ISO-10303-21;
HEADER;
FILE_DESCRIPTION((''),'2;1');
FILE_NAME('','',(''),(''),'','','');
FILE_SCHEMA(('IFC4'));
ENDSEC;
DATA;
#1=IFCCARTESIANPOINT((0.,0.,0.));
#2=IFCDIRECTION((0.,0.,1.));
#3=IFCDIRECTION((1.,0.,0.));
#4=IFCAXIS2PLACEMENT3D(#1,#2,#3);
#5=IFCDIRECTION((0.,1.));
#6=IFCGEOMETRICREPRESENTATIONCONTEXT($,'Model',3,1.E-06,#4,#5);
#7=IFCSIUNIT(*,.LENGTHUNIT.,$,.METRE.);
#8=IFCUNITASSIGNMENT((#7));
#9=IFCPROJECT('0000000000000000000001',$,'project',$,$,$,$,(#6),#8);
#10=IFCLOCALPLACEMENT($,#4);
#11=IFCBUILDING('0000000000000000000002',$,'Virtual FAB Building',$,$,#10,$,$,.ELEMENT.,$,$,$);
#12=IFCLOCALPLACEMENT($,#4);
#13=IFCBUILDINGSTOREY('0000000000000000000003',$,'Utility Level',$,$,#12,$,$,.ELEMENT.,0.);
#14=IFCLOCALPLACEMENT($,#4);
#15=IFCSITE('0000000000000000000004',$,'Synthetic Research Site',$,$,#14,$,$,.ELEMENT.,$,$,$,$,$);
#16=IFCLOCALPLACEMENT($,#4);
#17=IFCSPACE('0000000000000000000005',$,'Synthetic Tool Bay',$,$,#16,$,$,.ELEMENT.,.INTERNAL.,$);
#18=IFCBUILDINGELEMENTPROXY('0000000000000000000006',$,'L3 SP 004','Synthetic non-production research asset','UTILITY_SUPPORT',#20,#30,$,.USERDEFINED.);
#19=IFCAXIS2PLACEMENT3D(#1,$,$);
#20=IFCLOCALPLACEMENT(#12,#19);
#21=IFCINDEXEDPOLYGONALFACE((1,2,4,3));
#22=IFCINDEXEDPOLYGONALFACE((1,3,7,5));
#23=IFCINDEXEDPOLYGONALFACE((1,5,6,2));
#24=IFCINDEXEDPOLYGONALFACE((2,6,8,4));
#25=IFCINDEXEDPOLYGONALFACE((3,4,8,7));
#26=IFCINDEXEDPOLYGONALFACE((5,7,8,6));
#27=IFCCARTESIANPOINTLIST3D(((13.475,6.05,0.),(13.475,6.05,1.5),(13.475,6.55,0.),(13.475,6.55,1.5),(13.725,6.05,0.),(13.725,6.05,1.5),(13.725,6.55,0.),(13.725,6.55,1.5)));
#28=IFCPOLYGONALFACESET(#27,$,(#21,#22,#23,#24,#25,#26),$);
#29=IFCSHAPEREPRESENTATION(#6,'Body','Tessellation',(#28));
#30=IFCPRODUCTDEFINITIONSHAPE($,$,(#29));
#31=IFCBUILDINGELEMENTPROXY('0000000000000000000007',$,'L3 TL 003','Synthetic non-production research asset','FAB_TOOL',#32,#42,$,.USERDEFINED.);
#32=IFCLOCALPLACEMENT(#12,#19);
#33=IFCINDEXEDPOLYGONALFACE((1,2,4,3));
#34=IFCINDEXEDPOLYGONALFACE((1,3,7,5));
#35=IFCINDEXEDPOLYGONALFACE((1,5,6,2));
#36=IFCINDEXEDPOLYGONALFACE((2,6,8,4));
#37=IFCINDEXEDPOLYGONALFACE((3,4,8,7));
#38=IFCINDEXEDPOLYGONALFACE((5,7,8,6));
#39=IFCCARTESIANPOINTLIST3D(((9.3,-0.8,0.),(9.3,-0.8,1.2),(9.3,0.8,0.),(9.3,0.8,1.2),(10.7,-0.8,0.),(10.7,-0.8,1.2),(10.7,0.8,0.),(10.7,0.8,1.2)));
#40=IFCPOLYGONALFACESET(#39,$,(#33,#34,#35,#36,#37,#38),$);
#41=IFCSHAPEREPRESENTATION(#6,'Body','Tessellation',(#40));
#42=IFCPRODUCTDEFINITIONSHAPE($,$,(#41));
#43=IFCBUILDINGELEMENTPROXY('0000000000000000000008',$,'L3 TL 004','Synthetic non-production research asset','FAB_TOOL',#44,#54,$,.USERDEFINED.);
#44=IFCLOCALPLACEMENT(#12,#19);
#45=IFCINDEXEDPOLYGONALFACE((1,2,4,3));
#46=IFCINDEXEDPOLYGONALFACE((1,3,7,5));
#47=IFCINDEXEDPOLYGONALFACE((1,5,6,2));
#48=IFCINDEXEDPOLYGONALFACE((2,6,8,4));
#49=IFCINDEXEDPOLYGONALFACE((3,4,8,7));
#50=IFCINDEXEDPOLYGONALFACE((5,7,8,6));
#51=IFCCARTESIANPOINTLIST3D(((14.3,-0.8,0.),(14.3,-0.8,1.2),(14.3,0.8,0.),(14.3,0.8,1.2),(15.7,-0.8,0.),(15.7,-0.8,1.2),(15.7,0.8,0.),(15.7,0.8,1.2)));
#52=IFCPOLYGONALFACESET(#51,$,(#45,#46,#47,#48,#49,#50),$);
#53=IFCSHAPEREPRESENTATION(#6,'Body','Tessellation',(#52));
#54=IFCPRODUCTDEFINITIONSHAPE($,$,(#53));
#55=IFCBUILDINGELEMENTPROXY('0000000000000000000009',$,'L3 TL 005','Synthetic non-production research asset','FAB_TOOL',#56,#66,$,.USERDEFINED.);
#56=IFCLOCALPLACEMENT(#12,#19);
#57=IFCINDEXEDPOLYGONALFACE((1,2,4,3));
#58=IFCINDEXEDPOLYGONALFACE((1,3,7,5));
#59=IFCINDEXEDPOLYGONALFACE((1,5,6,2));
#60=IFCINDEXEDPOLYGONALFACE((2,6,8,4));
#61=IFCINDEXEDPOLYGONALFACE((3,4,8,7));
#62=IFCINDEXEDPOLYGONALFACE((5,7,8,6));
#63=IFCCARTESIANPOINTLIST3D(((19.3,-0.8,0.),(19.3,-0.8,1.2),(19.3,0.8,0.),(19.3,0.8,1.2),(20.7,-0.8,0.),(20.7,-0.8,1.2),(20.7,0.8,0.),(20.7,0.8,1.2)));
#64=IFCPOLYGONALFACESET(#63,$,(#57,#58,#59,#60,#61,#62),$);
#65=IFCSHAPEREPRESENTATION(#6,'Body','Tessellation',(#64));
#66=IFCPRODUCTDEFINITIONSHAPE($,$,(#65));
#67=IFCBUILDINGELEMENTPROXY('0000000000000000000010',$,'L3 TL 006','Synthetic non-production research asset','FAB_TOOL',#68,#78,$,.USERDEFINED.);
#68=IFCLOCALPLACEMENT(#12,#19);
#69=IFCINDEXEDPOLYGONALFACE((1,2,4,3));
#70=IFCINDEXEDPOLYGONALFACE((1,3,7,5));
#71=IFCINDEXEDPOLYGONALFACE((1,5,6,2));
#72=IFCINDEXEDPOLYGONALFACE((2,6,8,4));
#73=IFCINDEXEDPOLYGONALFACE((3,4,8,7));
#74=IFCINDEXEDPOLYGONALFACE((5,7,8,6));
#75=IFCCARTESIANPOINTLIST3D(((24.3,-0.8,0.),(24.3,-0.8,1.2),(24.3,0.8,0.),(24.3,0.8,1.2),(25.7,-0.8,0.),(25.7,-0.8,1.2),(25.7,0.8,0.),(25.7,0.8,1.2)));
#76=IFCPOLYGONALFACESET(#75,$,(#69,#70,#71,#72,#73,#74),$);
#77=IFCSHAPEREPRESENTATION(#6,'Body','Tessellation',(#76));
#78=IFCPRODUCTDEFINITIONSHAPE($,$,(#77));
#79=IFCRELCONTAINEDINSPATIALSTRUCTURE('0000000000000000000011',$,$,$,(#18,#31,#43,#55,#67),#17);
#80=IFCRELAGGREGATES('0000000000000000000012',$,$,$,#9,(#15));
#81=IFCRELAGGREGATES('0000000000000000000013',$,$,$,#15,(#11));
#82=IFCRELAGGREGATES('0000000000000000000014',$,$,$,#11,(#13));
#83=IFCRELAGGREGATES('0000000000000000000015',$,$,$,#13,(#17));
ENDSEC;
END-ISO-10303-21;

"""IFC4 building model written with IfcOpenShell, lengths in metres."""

from ifc_helpers import new_model, si_unit, direction, frame, origin_with_axes, origin_2d_with_axis, place, context, project, spatial, rectangle, extrude, element, save


model = new_model("IFC4")

# Units and contexts
model_context = context("Model", 3, precision=1e-06, world=origin_with_axes(), true_north=direction((0.0, 1.0)))
ifc_project = project(units=[si_unit("LENGTHUNIT", "METRE")], contexts=[model_context])

# Site, building, storey, space
site_placement = place(None, origin_with_axes())
site = spatial("IfcSite", under=ifc_project, at=site_placement, Name="Synthetic Research Site", CompositionType="ELEMENT")
building_placement = place(None, origin_with_axes())
building = spatial("IfcBuilding", under=site, at=building_placement, Name="Virtual FAB Building", CompositionType="ELEMENT")
storey_placement = place(None, origin_with_axes())
storey = spatial("IfcBuildingStorey", under=building, at=storey_placement, Name="Utility Level", CompositionType="ELEMENT", Elevation=0.0)
space_placement = place(None, origin_with_axes())
space = spatial("IfcSpace", under=storey, at=space_placement, Name="Synthetic Tool Bay", CompositionType="ELEMENT", PredefinedType="INTERNAL")

# Building element proxies
for number, where, z_axis, x_axis, name in (
    (1, (13.6, 6.3, 0.0), (0.0, 0.0, 1.0), (1.0, 0.0, 0.0), "L3 SP 004"),
):
    element("IfcBuildingElementProxy", number, at=place(None, frame(where, z_axis=z_axis, x_axis=x_axis)), inside=space, Name=name, Description="Synthetic non-production research asset", ObjectType="UTILITY_SUPPORT", PredefinedType="USERDEFINED", context=model_context, shape_type="SweptSolid", body=[
        extrude(rectangle(XDim=0.25, YDim=0.5, at=origin_2d_with_axis()), origin_with_axes(), (0.0, 0.0, 1.0), 1.5),
    ])
for number, where, z_axis, x_axis, name in (
    (2, (10.0, 0.0, 0.0), (0.0, 0.0, 1.0), (1.0, 0.0, 0.0), "L3 TL 003"),
    (3, (15.0, 0.0, 0.0), (0.0, 0.0, 1.0), (1.0, 0.0, 0.0), "L3 TL 004"),
    (4, (20.0, 0.0, 0.0), (0.0, 0.0, 1.0), (1.0, 0.0, 0.0), "L3 TL 005"),
    (5, (25.0, 0.0, 0.0), (0.0, 0.0, 1.0), (1.0, 0.0, 0.0), "L3 TL 006"),
):
    element("IfcBuildingElementProxy", number, at=place(None, frame(where, z_axis=z_axis, x_axis=x_axis)), inside=space, Name=name, Description="Synthetic non-production research asset", ObjectType="FAB_TOOL", PredefinedType="USERDEFINED", context=model_context, shape_type="SweptSolid", body=[
        extrude(rectangle(XDim=1.4, YDim=1.6, at=origin_2d_with_axis()), origin_with_axes(), (0.0, 0.0, 1.0), 1.2),
    ])

save(model, "model.ifc")
